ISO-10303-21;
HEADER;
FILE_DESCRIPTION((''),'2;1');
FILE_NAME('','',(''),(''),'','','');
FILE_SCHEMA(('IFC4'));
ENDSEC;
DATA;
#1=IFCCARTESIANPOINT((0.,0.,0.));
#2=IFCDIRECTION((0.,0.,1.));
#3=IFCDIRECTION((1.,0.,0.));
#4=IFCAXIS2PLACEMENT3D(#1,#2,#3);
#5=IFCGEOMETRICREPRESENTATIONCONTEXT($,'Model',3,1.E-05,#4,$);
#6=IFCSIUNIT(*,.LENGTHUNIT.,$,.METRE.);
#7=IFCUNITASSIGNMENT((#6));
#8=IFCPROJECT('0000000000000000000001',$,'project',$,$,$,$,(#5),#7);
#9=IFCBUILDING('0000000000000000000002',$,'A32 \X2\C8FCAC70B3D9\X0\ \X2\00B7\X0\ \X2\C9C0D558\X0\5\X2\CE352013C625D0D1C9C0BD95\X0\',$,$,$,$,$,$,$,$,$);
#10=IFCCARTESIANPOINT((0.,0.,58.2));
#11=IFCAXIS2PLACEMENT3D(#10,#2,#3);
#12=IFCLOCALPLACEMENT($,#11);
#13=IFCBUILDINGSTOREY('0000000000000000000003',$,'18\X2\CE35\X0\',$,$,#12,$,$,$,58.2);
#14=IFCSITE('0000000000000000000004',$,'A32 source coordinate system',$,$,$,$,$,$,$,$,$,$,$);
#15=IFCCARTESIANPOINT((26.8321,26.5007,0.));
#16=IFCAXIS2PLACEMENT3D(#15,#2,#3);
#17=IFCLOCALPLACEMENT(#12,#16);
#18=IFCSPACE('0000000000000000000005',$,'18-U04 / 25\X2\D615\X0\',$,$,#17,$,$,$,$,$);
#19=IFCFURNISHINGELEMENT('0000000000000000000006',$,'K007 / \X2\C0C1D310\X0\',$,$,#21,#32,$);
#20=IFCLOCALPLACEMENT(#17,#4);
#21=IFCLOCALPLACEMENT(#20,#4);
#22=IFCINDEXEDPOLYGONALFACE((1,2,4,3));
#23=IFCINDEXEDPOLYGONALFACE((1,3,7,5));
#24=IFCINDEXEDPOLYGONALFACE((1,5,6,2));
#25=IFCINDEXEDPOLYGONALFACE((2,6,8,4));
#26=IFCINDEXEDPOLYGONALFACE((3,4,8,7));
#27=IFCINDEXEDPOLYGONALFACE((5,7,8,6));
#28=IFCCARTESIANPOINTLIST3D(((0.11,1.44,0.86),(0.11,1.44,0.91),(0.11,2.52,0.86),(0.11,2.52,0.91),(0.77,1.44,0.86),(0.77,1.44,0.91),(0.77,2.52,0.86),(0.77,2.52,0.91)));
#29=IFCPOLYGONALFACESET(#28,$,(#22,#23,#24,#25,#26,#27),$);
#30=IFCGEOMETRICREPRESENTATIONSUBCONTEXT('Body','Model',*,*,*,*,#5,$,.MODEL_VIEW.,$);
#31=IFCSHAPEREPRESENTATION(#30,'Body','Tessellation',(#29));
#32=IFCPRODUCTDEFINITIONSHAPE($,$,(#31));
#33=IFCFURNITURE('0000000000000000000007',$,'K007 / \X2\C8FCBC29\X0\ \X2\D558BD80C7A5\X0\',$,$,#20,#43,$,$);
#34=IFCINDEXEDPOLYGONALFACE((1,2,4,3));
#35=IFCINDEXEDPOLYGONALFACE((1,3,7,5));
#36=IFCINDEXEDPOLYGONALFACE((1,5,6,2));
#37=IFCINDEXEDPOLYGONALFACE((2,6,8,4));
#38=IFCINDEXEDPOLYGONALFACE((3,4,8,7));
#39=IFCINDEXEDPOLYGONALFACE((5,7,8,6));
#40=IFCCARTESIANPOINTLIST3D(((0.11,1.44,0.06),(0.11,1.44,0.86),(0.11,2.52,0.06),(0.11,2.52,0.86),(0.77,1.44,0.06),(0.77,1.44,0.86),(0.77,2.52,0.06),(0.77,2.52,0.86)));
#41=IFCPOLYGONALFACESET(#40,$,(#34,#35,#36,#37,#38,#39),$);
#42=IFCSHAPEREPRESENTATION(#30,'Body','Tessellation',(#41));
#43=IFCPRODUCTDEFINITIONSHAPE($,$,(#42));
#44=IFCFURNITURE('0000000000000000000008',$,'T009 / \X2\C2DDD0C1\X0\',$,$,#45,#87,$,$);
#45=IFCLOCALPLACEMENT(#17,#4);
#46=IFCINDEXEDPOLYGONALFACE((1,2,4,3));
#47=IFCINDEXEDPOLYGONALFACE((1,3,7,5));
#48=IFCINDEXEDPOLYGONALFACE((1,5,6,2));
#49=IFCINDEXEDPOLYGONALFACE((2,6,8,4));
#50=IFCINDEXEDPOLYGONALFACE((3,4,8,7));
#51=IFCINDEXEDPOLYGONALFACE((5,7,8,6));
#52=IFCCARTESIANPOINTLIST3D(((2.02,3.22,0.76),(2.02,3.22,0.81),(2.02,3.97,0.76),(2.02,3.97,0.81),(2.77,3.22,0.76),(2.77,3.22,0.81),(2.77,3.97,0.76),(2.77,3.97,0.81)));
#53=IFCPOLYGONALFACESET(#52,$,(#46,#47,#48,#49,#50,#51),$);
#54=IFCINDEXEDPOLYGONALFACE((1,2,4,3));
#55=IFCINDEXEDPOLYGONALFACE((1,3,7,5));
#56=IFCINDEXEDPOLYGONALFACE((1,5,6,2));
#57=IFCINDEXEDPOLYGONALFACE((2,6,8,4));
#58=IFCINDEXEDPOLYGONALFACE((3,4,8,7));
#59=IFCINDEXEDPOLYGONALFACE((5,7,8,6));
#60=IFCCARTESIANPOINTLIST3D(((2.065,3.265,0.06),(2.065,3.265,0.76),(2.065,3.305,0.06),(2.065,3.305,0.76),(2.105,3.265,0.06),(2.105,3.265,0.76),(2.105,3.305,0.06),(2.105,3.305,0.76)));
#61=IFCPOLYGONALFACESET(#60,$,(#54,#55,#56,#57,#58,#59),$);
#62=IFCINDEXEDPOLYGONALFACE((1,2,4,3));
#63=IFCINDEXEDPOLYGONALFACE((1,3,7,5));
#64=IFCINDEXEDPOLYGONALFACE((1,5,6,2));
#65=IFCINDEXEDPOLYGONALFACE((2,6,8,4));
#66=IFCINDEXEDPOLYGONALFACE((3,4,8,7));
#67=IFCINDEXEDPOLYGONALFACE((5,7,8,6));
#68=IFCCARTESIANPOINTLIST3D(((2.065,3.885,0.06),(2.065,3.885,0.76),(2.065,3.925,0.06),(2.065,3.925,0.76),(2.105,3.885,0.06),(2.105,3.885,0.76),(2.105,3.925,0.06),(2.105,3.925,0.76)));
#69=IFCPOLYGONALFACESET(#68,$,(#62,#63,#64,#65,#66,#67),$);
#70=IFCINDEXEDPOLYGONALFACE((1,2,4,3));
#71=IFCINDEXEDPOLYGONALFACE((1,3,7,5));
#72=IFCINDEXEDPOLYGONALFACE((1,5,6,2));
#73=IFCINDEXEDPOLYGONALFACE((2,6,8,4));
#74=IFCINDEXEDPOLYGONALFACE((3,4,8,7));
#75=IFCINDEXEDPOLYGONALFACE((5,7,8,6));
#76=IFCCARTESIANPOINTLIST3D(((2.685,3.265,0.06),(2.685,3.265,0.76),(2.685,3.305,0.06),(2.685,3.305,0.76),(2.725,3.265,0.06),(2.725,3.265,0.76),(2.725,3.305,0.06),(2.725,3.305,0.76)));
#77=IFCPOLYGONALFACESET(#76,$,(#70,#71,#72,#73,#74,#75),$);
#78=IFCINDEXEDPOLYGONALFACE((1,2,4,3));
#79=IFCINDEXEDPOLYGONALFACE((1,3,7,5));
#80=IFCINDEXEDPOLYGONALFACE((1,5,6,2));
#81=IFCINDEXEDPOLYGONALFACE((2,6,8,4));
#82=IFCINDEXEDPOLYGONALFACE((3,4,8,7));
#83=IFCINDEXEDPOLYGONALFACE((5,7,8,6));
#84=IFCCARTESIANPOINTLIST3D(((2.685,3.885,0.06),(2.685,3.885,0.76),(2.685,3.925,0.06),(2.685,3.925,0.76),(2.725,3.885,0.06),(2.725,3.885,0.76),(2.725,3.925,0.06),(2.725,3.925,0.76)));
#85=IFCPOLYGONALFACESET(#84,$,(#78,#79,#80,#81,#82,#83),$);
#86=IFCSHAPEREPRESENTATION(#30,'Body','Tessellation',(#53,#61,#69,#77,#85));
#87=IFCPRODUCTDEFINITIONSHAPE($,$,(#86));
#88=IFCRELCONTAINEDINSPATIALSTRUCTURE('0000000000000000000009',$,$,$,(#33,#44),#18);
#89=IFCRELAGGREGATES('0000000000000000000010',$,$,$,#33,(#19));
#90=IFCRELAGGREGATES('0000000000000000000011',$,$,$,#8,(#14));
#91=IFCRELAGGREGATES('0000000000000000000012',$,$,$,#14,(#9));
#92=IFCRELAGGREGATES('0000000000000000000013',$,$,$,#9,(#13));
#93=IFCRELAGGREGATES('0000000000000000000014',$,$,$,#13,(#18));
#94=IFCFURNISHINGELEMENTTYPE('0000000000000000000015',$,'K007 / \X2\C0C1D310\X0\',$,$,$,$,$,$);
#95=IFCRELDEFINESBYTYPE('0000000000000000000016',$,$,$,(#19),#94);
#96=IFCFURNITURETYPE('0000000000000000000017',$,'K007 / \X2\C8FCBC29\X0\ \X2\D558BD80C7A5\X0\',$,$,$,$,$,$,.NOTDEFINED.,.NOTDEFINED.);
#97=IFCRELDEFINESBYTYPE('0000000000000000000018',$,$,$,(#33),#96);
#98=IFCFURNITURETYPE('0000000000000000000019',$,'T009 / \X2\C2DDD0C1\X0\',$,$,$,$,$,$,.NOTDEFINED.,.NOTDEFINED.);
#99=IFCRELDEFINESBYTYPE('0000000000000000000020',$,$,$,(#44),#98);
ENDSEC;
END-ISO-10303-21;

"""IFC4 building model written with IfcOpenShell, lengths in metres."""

from ifc_helpers import new_model, si_unit, frame, origin, origin_with_axes, place, context, subcontext, project, spatial, polyline, outline, extrude, source, transform, mapped, type_object, type_shapes, element, aggregate, save


model = new_model("IFC4")

# Units and contexts
model_context = context("Model", 3, precision=1e-05, world=origin_with_axes())
body_context = subcontext(model_context, "Body", "Model", "MODEL_VIEW")
ifc_project = project(units=[si_unit("LENGTHUNIT", "METRE")], contexts=[model_context])

# Site, building, storey
site = spatial("IfcSite", under=ifc_project, Name="A32 source coordinate system")
building = spatial("IfcBuilding", under=site, Name="A32 주거동 · 지하5층–옥탑지붕")
storey_placement = place(None, frame((0.0, 0.0, 58.2), z_axis=(0.0, 0.0, 1.0), x_axis=(1.0, 0.0, 0.0)))
storey = spatial("IfcBuildingStorey", under=building, at=storey_placement, Name="18층", Elevation=58.2)

# Shared definitions
space_1_placement = place(storey_placement, frame((26.8321, 26.5007, 0.0), z_axis=(0.0, 0.0, 1.0), x_axis=(1.0, 0.0, 0.0)))
space_1 = spatial("IfcSpace", under=storey, at=space_1_placement, Name="18-U04 / 25형")

# Furnishing element
furnishing_element_type_1 = type_object("IfcFurnishingElementType", Name="K007 / 상판")
shared_shape_1 = source(origin(), body_context, "Body", "SweptSolid", [
    extrude(outline(polyline([(0.77, 2.52), (0.77, 1.44), (0.11, 1.44), (0.11, 2.52), (0.77, 2.52)])), frame((0.0, 0.0, 0.86)), (0.0, 0.0, 1.0), 0.05),
])
type_shapes(furnishing_element_type_1, [shared_shape_1])
furniture_1_placement = place(space_1_placement, origin_with_axes())
furnishing_1_placement = place(furniture_1_placement, origin_with_axes())
furnishing_1 = element("IfcFurnishingElement", 1, at=furnishing_1_placement, type_object=furnishing_element_type_1, Name="K007 / 상판", context=body_context, shape_type="MappedRepresentation", body=[
    mapped(shared_shape_1, transform((0.0, 0.0, 0.0), scale=1.0)),
])

# Furniture
furniture_type_1 = type_object("IfcFurnitureType", Name="K007 / 주방 하부장", AssemblyPlace="NOTDEFINED", PredefinedType="NOTDEFINED")
shared_shape_2 = source(origin(), body_context, "Body", "SweptSolid", [
    extrude(outline(polyline([(0.11, 2.52), (0.77, 2.52), (0.77, 1.44), (0.11, 1.44), (0.11, 2.52)])), frame((0.0, 0.0, 0.06)), (0.0, 0.0, 1.0), 0.8),
])
type_shapes(furniture_type_1, [shared_shape_2])
furniture_1 = element("IfcFurniture", 2, at=furniture_1_placement, inside=space_1, type_object=furniture_type_1, Name="K007 / 주방 하부장", context=body_context, shape_type="MappedRepresentation", body=[
    mapped(shared_shape_2, transform((0.0, 0.0, 0.0), scale=1.0)),
])
aggregate(furniture_1, [furnishing_1])
furniture_type_2 = type_object("IfcFurnitureType", Name="T009 / 식탁", AssemblyPlace="NOTDEFINED", PredefinedType="NOTDEFINED")
shared_shape_3 = source(origin(), body_context, "Body", "SweptSolid", [
    extrude(outline(polyline([(2.77, 3.22), (2.02, 3.22), (2.02, 3.97), (2.77, 3.97), (2.77, 3.22)])), frame((0.0, 0.0, 0.76)), (0.0, 0.0, 1.0), 0.05),
    extrude(outline(polyline([(2.065, 3.265), (2.065, 3.305), (2.105, 3.305), (2.105, 3.265), (2.065, 3.265)])), frame((0.0, 0.0, 0.06)), (0.0, 0.0, 1.0), 0.7),
    extrude(outline(polyline([(2.065, 3.885), (2.065, 3.925), (2.105, 3.925), (2.105, 3.885), (2.065, 3.885)])), frame((0.0, 0.0, 0.06)), (0.0, 0.0, 1.0), 0.7),
    extrude(outline(polyline([(2.685, 3.265), (2.685, 3.305), (2.725, 3.305), (2.725, 3.265), (2.685, 3.265)])), frame((0.0, 0.0, 0.06)), (0.0, 0.0, 1.0), 0.7),
    extrude(outline(polyline([(2.685, 3.885), (2.685, 3.925), (2.725, 3.925), (2.725, 3.885), (2.685, 3.885)])), frame((0.0, 0.0, 0.06)), (0.0, 0.0, 1.0), 0.7),
])
type_shapes(furniture_type_2, [shared_shape_3])
furniture_2_placement = place(space_1_placement, origin_with_axes())
element("IfcFurniture", 3, at=furniture_2_placement, inside=space_1, type_object=furniture_type_2, Name="T009 / 식탁", context=body_context, shape_type="MappedRepresentation", body=[
    mapped(shared_shape_3, transform((0.0, 0.0, 0.0), scale=1.0)),
])

save(model, "model.ifc")
